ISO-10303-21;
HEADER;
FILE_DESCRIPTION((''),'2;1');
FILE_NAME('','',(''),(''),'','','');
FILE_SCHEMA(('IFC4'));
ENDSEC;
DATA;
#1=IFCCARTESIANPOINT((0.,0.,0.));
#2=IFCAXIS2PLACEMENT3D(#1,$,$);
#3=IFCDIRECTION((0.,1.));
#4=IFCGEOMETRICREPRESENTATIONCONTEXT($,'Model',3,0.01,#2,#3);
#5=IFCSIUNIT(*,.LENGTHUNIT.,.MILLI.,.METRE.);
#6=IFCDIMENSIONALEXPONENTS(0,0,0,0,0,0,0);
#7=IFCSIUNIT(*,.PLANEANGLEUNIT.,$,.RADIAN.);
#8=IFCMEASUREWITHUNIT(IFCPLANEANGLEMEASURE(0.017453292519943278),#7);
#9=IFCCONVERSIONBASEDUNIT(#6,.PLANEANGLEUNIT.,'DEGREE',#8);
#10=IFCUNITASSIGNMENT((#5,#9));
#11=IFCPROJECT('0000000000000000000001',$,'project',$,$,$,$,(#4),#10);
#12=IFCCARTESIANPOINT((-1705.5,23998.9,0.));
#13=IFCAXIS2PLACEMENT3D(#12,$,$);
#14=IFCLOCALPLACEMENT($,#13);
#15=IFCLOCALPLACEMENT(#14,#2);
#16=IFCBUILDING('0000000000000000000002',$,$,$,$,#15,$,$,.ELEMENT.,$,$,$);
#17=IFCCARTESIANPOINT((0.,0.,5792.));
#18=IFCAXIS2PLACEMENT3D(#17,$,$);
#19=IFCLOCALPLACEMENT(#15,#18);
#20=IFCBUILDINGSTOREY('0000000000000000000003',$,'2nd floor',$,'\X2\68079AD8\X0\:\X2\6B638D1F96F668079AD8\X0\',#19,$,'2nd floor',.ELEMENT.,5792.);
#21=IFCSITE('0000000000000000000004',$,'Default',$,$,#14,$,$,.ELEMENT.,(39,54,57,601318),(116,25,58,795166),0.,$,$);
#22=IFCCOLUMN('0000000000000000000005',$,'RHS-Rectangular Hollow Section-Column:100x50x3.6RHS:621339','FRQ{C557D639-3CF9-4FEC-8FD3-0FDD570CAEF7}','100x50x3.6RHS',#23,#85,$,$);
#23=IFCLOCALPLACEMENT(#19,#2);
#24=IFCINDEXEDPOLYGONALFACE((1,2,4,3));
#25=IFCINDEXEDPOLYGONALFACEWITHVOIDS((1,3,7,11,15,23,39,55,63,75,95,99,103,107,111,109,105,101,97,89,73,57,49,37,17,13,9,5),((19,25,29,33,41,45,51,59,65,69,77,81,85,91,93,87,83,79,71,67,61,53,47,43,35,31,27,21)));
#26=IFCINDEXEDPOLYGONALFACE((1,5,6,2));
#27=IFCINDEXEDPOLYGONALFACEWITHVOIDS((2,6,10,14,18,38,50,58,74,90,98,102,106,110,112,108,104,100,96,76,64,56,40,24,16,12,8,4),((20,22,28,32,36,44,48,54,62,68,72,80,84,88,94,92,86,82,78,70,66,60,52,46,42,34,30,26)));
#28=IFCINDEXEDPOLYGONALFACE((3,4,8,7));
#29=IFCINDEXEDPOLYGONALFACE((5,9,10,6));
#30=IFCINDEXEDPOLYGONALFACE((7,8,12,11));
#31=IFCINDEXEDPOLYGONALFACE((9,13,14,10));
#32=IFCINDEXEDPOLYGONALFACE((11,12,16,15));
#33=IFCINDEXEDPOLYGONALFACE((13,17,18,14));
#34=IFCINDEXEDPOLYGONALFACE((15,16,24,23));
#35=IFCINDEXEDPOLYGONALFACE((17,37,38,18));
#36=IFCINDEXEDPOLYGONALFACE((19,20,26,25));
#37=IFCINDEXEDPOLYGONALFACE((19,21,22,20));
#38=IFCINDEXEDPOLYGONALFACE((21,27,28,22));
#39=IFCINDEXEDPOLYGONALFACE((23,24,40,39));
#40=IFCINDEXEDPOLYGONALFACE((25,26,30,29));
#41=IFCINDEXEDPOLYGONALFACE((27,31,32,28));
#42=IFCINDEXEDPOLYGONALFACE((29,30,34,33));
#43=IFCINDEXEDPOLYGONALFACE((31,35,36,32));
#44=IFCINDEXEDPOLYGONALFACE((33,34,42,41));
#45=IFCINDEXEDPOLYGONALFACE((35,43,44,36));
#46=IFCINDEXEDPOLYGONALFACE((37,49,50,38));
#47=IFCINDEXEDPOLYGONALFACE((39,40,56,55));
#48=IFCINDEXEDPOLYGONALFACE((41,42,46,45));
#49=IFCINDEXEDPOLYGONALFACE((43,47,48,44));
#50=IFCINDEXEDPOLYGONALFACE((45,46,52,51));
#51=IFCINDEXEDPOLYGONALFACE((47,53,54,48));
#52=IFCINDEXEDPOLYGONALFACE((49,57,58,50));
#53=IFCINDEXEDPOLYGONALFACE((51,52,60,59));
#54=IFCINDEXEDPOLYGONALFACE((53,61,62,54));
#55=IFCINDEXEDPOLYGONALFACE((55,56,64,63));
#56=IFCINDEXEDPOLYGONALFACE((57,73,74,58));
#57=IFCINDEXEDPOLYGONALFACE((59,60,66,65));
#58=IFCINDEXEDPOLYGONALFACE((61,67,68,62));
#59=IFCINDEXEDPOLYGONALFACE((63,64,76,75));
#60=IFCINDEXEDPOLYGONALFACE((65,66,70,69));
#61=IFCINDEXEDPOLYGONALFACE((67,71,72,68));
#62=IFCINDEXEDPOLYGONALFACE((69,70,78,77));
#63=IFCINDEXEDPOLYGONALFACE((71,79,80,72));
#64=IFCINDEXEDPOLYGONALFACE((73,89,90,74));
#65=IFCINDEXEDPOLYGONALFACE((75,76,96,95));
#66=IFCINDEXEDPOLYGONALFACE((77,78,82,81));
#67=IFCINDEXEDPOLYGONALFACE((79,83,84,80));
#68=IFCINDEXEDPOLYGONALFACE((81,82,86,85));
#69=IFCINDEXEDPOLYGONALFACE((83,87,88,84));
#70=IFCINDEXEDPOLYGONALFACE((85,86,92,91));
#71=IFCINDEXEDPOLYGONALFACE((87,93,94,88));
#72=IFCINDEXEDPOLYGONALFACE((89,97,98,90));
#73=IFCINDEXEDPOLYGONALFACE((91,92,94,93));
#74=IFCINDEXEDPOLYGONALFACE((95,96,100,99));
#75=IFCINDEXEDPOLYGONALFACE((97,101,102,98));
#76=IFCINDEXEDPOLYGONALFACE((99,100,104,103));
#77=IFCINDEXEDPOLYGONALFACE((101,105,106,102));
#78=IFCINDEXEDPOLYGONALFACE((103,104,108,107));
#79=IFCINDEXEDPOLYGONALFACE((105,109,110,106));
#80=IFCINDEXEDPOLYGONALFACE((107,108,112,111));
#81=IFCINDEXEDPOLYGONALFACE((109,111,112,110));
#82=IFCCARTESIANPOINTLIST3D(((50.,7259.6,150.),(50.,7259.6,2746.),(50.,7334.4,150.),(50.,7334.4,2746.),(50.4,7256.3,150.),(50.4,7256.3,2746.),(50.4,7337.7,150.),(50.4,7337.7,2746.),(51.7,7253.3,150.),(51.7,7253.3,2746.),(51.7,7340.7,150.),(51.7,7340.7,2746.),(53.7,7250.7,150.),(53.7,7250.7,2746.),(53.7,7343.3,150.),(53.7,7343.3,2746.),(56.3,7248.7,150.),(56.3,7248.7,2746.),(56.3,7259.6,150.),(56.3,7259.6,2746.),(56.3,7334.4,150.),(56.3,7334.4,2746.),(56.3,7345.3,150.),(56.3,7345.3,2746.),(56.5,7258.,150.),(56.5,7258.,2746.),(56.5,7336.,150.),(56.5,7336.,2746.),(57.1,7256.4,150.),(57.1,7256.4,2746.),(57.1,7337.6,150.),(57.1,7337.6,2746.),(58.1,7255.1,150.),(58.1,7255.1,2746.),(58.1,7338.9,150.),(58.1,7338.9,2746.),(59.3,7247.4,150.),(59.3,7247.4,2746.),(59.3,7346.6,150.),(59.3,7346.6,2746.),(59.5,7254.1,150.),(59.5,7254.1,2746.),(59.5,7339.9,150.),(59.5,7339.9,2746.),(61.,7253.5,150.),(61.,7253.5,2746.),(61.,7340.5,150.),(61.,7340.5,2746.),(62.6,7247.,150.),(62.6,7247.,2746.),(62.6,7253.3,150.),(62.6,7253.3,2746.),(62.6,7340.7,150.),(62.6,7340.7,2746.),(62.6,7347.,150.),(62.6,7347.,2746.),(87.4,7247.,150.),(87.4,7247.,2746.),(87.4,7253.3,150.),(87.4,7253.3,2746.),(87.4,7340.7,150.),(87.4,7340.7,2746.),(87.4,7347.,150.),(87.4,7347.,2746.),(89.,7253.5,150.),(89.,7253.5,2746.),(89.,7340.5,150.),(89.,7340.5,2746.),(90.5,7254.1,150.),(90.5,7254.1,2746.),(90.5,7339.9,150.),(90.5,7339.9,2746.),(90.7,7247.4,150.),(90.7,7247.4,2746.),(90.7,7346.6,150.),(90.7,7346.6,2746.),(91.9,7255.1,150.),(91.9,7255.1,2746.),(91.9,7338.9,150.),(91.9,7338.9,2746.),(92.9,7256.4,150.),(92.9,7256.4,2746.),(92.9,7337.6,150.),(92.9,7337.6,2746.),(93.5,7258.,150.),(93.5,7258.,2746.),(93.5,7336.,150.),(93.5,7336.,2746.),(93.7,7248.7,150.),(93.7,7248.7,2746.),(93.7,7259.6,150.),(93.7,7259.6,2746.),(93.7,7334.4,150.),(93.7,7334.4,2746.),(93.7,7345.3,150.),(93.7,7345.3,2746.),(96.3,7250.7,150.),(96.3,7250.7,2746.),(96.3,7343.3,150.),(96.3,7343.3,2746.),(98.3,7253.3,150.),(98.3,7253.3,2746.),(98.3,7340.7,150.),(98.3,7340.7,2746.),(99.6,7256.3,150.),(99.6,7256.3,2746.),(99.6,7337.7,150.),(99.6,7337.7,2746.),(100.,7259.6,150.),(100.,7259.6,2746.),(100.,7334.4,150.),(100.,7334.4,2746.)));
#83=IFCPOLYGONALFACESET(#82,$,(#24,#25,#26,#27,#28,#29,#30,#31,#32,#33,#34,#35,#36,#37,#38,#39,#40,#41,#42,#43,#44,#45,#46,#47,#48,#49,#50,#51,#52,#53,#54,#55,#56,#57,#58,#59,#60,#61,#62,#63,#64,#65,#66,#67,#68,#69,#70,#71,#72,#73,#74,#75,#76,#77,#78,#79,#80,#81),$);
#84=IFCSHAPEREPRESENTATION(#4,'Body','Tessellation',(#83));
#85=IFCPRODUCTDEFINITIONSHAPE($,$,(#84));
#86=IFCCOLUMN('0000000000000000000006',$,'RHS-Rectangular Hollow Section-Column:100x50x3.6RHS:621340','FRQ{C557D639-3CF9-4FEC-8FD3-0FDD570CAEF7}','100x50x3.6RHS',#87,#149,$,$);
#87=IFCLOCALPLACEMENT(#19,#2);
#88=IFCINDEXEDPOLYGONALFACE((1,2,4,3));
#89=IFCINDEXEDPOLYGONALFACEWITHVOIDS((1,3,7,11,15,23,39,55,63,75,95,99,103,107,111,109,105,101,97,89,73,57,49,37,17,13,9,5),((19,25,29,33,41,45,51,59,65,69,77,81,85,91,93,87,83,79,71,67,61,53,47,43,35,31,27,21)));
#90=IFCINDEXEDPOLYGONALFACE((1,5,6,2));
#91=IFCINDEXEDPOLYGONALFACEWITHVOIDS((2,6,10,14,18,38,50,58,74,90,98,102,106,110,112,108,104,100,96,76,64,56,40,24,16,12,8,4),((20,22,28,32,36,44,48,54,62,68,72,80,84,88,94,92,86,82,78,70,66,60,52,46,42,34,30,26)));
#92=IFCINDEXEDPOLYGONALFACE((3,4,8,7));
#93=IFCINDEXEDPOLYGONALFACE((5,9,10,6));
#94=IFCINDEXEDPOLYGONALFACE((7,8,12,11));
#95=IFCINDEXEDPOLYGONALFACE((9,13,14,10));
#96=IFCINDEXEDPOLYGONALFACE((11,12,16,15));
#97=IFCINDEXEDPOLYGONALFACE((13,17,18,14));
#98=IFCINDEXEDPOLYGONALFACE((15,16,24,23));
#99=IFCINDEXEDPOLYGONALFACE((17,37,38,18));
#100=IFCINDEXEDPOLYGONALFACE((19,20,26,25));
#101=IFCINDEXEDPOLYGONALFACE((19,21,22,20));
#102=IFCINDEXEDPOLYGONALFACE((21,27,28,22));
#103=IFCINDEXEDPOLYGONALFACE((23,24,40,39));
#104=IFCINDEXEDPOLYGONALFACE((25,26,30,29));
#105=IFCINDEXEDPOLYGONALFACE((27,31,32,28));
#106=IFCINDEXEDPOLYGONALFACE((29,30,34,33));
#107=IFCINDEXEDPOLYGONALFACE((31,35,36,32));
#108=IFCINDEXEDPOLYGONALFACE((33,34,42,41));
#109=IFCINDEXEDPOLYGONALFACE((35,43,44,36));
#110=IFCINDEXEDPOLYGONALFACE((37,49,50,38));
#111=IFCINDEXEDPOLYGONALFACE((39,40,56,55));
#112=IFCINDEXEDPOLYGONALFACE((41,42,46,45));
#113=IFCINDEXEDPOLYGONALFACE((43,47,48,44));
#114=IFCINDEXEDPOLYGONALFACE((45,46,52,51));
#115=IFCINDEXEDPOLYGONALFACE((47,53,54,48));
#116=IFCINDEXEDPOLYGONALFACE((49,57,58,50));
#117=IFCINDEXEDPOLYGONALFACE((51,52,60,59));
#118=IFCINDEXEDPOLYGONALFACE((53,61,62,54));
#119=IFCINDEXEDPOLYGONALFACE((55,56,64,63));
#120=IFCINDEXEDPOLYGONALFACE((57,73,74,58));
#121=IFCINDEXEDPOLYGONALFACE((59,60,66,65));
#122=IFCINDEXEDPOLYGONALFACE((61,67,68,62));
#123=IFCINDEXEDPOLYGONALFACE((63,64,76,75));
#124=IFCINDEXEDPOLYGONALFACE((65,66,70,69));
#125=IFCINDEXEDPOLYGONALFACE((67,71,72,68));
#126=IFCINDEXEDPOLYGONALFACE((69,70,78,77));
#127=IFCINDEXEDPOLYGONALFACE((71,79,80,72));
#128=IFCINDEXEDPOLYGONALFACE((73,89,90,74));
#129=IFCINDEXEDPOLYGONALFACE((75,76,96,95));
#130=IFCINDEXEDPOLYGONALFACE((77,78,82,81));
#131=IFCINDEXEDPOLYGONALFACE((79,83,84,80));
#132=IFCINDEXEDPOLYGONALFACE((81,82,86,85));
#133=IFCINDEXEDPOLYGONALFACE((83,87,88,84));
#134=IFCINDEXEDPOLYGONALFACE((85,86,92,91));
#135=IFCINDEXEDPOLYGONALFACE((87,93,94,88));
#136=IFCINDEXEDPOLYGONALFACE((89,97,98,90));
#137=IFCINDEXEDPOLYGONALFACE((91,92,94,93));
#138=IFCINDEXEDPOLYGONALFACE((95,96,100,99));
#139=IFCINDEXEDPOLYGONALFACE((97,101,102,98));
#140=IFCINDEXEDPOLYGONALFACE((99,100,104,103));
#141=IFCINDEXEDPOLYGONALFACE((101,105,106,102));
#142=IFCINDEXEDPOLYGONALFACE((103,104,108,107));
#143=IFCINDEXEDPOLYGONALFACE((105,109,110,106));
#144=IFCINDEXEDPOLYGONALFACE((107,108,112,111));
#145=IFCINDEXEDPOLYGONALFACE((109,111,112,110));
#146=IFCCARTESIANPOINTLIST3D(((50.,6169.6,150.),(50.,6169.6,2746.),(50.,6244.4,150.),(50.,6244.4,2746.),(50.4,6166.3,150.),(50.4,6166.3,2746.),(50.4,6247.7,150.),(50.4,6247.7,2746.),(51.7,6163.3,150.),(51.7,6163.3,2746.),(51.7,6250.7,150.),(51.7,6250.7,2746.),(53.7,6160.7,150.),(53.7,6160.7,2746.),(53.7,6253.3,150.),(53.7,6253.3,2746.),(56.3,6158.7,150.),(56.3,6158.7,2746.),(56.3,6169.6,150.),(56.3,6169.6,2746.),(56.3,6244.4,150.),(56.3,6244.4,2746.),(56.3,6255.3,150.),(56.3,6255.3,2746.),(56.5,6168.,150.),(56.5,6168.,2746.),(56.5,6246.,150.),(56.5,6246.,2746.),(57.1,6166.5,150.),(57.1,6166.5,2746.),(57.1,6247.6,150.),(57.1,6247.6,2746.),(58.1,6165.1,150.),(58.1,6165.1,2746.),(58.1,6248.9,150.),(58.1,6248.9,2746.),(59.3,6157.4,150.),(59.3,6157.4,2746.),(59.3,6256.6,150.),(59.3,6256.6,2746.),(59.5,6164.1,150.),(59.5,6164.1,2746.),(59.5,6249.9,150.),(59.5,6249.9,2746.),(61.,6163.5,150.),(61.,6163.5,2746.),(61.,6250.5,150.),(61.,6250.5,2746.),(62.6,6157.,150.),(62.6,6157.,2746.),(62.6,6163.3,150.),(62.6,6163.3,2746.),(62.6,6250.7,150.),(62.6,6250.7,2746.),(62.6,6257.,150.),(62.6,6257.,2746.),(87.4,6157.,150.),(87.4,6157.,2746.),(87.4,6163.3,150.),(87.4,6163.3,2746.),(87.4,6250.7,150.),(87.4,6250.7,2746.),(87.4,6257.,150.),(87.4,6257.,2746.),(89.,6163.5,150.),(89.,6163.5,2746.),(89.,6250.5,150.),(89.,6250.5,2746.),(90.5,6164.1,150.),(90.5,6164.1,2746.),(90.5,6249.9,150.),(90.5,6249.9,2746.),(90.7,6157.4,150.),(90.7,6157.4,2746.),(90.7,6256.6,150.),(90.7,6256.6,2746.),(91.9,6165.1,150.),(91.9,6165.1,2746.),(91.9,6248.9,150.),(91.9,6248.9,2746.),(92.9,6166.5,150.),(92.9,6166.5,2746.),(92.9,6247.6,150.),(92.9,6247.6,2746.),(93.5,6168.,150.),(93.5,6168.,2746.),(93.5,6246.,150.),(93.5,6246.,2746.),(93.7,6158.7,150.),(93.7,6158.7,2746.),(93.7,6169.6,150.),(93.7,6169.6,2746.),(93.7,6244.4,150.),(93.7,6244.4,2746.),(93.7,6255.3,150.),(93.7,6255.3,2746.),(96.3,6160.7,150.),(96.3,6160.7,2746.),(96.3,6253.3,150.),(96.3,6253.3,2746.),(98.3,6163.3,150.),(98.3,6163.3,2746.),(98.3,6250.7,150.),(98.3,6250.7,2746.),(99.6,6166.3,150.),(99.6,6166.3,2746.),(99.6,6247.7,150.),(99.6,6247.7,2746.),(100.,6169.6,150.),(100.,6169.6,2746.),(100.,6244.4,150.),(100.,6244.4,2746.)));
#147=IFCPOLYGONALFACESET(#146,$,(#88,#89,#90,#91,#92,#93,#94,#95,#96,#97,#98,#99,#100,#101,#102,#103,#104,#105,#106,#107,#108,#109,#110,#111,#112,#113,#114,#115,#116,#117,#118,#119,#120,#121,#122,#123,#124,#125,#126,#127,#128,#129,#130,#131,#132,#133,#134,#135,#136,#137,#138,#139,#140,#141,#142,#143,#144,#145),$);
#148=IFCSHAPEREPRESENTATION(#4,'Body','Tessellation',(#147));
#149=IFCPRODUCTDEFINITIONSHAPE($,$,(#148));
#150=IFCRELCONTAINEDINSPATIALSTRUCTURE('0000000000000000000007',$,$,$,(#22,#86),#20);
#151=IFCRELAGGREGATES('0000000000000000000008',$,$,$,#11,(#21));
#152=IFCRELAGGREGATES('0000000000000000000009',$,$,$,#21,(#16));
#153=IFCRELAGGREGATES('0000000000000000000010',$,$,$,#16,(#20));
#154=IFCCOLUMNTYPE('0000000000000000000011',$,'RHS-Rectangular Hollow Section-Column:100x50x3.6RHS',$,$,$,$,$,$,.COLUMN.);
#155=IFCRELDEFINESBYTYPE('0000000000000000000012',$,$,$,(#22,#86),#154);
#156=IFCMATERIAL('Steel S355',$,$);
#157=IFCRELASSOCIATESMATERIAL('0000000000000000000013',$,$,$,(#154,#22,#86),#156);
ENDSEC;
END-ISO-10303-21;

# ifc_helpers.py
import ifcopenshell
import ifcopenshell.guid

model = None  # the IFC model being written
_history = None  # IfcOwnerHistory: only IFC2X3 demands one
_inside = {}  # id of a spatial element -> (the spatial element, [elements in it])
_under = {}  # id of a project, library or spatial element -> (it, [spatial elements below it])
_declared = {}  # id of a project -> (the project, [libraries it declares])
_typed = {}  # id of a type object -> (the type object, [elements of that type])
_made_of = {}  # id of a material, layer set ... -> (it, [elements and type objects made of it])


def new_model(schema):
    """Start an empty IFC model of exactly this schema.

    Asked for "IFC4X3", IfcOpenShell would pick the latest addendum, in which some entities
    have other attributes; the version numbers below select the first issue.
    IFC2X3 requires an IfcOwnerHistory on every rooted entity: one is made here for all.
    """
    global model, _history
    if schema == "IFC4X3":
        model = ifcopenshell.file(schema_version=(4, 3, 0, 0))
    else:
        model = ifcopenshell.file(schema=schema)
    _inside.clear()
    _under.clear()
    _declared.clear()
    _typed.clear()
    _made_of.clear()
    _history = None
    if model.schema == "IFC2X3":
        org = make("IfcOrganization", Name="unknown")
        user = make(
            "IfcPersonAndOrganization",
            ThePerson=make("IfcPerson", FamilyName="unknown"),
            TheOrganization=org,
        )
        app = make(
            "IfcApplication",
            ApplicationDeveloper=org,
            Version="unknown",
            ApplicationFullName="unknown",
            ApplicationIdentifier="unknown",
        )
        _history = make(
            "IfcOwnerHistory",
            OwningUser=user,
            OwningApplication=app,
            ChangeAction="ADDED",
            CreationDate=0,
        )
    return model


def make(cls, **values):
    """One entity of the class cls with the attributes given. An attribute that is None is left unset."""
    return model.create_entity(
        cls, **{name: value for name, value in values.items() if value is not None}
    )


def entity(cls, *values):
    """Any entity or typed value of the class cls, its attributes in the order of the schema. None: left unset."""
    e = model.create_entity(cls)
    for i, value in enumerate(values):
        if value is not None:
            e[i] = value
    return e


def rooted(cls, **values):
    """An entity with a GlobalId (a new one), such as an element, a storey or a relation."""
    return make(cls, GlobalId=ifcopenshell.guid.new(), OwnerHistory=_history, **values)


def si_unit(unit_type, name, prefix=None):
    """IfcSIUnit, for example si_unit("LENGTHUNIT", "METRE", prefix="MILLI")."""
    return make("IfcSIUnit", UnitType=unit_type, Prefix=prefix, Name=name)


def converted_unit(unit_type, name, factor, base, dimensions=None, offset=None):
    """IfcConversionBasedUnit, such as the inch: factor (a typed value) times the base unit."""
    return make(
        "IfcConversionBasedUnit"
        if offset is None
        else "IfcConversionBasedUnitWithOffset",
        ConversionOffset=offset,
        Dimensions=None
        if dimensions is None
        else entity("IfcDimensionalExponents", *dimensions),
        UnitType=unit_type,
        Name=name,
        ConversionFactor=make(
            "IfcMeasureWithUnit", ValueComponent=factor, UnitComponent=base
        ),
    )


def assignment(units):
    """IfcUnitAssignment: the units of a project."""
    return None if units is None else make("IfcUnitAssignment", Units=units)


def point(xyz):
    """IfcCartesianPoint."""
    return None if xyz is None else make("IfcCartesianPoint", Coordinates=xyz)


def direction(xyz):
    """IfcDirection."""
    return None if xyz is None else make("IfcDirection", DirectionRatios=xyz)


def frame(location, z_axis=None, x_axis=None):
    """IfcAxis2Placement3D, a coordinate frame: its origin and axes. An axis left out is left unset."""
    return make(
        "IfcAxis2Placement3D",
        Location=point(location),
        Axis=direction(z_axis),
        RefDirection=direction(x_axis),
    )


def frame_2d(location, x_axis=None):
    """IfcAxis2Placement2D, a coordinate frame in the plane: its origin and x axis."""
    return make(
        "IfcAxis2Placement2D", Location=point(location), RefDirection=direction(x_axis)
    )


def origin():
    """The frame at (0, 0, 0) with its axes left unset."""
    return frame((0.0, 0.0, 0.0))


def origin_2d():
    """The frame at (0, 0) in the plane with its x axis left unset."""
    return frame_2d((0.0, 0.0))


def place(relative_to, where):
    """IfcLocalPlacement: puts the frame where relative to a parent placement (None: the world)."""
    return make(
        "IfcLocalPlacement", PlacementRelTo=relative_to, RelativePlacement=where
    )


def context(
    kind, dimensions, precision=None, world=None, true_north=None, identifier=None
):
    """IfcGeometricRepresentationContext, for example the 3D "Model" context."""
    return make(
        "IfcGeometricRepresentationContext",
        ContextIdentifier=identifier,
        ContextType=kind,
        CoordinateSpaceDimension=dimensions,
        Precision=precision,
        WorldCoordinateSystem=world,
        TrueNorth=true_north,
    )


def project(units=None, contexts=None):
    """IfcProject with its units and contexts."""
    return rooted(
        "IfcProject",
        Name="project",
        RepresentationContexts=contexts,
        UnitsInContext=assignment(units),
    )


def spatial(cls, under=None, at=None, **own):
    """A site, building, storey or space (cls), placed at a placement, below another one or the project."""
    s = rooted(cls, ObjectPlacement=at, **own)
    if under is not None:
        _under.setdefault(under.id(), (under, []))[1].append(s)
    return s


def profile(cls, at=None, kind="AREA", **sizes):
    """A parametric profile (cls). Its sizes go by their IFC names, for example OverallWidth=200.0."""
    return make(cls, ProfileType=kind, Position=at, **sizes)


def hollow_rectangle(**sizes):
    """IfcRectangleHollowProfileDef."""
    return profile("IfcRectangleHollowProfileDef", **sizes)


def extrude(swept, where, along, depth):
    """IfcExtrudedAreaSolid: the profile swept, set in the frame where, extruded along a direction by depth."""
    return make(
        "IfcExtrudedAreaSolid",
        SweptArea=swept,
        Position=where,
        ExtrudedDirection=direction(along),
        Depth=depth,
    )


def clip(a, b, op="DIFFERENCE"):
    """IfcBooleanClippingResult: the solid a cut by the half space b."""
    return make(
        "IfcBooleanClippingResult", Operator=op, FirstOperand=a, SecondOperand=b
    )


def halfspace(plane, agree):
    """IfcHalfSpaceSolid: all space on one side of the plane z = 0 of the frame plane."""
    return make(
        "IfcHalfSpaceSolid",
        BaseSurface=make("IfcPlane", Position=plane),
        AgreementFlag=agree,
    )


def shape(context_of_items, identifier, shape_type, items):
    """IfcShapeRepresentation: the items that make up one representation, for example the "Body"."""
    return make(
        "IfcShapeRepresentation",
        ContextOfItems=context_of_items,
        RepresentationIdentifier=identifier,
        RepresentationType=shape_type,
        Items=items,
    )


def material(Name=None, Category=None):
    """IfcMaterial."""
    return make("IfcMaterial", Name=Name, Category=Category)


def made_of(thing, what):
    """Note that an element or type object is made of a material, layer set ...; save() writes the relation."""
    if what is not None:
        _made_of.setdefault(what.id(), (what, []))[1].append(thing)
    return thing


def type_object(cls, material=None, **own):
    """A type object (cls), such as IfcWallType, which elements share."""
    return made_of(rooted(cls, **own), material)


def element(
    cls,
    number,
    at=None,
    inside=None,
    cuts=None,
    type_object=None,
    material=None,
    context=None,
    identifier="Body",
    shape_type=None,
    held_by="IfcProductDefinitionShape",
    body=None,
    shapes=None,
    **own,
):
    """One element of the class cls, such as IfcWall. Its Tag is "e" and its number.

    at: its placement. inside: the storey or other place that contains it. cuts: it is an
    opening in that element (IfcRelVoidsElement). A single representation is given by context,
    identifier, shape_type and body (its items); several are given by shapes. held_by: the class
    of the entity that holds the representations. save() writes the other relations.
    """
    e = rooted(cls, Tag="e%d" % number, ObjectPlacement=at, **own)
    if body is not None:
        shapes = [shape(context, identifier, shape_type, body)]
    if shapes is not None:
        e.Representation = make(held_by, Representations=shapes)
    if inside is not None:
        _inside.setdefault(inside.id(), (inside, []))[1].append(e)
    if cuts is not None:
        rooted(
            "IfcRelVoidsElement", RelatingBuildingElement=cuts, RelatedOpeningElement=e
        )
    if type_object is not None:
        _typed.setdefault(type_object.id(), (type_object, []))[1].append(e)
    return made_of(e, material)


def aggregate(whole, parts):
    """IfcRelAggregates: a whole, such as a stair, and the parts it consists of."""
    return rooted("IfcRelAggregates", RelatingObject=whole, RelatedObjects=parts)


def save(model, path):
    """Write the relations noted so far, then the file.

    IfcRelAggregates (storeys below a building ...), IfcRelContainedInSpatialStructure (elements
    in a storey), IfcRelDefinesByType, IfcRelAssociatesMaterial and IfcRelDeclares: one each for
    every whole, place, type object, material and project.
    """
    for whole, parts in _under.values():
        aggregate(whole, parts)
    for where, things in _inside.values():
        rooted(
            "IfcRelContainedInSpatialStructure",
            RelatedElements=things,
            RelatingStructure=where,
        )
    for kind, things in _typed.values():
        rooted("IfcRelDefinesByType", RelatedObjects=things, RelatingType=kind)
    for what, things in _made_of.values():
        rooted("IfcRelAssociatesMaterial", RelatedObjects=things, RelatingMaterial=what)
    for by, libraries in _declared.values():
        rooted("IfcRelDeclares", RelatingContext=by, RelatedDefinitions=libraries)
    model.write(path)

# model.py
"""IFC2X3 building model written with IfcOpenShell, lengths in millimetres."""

from ifc_helpers import new_model, entity, si_unit, converted_unit, direction, frame, origin, origin_2d, place, context, project, spatial, hollow_rectangle, extrude, clip, halfspace, material, type_object, element, save


model = new_model("IFC2X3")

# Units and contexts
model_context = context("Model", 3, precision=0.01, world=origin(), true_north=direction((0.0, 1.0)))
ifc_project = project(units=[si_unit("LENGTHUNIT", "METRE", prefix="MILLI"), converted_unit("PLANEANGLEUNIT", "DEGREE", entity("IfcPlaneAngleMeasure", 0.017453292519943278), si_unit("PLANEANGLEUNIT", "RADIAN"), dimensions=[0, 0, 0, 0, 0, 0, 0])], contexts=[model_context])

# Site, building, storey
site_placement = place(None, frame((-1705.5, 23998.9, 0.0)))
site = spatial("IfcSite", under=ifc_project, at=site_placement, Name="Default", CompositionType="ELEMENT", RefLatitude=(39, 54, 57, 601318), RefLongitude=(116, 25, 58, 795166), RefElevation=0.0)
building_placement = place(site_placement, origin())
building = spatial("IfcBuilding", under=site, at=building_placement, CompositionType="ELEMENT")
storey_placement = place(building_placement, frame((0.0, 0.0, 5792.0)))
storey = spatial("IfcBuildingStorey", under=building, at=storey_placement, Name="2nd floor", ObjectType="标高:正负零标高", LongName="2nd floor", CompositionType="ELEMENT", Elevation=5792.0)

# Columns
ifc_material_1 = material(Name="Steel S355")
column_type_1 = type_object("IfcColumnType", Name="RHS-Rectangular Hollow Section-Column:100x50x3.6RHS", PredefinedType="COLUMN", material=ifc_material_1)
column_1_placement = place(storey_placement, frame((75.0, 7297.0, 2746.0), z_axis=(0.0, 0.0, 1.0), x_axis=(-1.0, 0.0, 0.0)))
element("IfcColumn", 1, at=column_1_placement, inside=storey, type_object=column_type_1, material=ifc_material_1, Name="RHS-Rectangular Hollow Section-Column:100x50x3.6RHS:621339", Description="FRQ{C557D639-3CF9-4FEC-8FD3-0FDD570CAEF7}", ObjectType="100x50x3.6RHS", context=model_context, shape_type="Clipping", body=[
    clip(extrude(hollow_rectangle(XDim=50.0, YDim=100.0, WallThickness=6.3, InnerFilletRadius=6.3, OuterFilletRadius=12.6, at=origin_2d()), origin(), (0.0, 0.0, -1.0), 2651.9), halfspace(frame((75.0, 7297.0, -2596.0), z_axis=(0.0, 0.0, 1.0), x_axis=(-1.0, 0.0, 0.0)), True)),
])
column_2_placement = place(storey_placement, frame((75.0, 6207.0, 2746.0), z_axis=(0.0, 0.0, 1.0), x_axis=(-1.0, 0.0, 0.0)))
element("IfcColumn", 2, at=column_2_placement, inside=storey, type_object=column_type_1, material=ifc_material_1, Name="RHS-Rectangular Hollow Section-Column:100x50x3.6RHS:621340", Description="FRQ{C557D639-3CF9-4FEC-8FD3-0FDD570CAEF7}", ObjectType="100x50x3.6RHS", context=model_context, shape_type="Clipping", body=[
    clip(extrude(hollow_rectangle(XDim=50.0, YDim=100.0, WallThickness=6.3, InnerFilletRadius=6.3, OuterFilletRadius=12.6, at=origin_2d()), origin(), (0.0, 0.0, -1.0), 2651.9), halfspace(frame((75.0, 6207.0, -2596.0), z_axis=(0.0, 0.0, 1.0), x_axis=(-1.0, 0.0, 0.0)), True)),
])

save(model, "model.ifc")
